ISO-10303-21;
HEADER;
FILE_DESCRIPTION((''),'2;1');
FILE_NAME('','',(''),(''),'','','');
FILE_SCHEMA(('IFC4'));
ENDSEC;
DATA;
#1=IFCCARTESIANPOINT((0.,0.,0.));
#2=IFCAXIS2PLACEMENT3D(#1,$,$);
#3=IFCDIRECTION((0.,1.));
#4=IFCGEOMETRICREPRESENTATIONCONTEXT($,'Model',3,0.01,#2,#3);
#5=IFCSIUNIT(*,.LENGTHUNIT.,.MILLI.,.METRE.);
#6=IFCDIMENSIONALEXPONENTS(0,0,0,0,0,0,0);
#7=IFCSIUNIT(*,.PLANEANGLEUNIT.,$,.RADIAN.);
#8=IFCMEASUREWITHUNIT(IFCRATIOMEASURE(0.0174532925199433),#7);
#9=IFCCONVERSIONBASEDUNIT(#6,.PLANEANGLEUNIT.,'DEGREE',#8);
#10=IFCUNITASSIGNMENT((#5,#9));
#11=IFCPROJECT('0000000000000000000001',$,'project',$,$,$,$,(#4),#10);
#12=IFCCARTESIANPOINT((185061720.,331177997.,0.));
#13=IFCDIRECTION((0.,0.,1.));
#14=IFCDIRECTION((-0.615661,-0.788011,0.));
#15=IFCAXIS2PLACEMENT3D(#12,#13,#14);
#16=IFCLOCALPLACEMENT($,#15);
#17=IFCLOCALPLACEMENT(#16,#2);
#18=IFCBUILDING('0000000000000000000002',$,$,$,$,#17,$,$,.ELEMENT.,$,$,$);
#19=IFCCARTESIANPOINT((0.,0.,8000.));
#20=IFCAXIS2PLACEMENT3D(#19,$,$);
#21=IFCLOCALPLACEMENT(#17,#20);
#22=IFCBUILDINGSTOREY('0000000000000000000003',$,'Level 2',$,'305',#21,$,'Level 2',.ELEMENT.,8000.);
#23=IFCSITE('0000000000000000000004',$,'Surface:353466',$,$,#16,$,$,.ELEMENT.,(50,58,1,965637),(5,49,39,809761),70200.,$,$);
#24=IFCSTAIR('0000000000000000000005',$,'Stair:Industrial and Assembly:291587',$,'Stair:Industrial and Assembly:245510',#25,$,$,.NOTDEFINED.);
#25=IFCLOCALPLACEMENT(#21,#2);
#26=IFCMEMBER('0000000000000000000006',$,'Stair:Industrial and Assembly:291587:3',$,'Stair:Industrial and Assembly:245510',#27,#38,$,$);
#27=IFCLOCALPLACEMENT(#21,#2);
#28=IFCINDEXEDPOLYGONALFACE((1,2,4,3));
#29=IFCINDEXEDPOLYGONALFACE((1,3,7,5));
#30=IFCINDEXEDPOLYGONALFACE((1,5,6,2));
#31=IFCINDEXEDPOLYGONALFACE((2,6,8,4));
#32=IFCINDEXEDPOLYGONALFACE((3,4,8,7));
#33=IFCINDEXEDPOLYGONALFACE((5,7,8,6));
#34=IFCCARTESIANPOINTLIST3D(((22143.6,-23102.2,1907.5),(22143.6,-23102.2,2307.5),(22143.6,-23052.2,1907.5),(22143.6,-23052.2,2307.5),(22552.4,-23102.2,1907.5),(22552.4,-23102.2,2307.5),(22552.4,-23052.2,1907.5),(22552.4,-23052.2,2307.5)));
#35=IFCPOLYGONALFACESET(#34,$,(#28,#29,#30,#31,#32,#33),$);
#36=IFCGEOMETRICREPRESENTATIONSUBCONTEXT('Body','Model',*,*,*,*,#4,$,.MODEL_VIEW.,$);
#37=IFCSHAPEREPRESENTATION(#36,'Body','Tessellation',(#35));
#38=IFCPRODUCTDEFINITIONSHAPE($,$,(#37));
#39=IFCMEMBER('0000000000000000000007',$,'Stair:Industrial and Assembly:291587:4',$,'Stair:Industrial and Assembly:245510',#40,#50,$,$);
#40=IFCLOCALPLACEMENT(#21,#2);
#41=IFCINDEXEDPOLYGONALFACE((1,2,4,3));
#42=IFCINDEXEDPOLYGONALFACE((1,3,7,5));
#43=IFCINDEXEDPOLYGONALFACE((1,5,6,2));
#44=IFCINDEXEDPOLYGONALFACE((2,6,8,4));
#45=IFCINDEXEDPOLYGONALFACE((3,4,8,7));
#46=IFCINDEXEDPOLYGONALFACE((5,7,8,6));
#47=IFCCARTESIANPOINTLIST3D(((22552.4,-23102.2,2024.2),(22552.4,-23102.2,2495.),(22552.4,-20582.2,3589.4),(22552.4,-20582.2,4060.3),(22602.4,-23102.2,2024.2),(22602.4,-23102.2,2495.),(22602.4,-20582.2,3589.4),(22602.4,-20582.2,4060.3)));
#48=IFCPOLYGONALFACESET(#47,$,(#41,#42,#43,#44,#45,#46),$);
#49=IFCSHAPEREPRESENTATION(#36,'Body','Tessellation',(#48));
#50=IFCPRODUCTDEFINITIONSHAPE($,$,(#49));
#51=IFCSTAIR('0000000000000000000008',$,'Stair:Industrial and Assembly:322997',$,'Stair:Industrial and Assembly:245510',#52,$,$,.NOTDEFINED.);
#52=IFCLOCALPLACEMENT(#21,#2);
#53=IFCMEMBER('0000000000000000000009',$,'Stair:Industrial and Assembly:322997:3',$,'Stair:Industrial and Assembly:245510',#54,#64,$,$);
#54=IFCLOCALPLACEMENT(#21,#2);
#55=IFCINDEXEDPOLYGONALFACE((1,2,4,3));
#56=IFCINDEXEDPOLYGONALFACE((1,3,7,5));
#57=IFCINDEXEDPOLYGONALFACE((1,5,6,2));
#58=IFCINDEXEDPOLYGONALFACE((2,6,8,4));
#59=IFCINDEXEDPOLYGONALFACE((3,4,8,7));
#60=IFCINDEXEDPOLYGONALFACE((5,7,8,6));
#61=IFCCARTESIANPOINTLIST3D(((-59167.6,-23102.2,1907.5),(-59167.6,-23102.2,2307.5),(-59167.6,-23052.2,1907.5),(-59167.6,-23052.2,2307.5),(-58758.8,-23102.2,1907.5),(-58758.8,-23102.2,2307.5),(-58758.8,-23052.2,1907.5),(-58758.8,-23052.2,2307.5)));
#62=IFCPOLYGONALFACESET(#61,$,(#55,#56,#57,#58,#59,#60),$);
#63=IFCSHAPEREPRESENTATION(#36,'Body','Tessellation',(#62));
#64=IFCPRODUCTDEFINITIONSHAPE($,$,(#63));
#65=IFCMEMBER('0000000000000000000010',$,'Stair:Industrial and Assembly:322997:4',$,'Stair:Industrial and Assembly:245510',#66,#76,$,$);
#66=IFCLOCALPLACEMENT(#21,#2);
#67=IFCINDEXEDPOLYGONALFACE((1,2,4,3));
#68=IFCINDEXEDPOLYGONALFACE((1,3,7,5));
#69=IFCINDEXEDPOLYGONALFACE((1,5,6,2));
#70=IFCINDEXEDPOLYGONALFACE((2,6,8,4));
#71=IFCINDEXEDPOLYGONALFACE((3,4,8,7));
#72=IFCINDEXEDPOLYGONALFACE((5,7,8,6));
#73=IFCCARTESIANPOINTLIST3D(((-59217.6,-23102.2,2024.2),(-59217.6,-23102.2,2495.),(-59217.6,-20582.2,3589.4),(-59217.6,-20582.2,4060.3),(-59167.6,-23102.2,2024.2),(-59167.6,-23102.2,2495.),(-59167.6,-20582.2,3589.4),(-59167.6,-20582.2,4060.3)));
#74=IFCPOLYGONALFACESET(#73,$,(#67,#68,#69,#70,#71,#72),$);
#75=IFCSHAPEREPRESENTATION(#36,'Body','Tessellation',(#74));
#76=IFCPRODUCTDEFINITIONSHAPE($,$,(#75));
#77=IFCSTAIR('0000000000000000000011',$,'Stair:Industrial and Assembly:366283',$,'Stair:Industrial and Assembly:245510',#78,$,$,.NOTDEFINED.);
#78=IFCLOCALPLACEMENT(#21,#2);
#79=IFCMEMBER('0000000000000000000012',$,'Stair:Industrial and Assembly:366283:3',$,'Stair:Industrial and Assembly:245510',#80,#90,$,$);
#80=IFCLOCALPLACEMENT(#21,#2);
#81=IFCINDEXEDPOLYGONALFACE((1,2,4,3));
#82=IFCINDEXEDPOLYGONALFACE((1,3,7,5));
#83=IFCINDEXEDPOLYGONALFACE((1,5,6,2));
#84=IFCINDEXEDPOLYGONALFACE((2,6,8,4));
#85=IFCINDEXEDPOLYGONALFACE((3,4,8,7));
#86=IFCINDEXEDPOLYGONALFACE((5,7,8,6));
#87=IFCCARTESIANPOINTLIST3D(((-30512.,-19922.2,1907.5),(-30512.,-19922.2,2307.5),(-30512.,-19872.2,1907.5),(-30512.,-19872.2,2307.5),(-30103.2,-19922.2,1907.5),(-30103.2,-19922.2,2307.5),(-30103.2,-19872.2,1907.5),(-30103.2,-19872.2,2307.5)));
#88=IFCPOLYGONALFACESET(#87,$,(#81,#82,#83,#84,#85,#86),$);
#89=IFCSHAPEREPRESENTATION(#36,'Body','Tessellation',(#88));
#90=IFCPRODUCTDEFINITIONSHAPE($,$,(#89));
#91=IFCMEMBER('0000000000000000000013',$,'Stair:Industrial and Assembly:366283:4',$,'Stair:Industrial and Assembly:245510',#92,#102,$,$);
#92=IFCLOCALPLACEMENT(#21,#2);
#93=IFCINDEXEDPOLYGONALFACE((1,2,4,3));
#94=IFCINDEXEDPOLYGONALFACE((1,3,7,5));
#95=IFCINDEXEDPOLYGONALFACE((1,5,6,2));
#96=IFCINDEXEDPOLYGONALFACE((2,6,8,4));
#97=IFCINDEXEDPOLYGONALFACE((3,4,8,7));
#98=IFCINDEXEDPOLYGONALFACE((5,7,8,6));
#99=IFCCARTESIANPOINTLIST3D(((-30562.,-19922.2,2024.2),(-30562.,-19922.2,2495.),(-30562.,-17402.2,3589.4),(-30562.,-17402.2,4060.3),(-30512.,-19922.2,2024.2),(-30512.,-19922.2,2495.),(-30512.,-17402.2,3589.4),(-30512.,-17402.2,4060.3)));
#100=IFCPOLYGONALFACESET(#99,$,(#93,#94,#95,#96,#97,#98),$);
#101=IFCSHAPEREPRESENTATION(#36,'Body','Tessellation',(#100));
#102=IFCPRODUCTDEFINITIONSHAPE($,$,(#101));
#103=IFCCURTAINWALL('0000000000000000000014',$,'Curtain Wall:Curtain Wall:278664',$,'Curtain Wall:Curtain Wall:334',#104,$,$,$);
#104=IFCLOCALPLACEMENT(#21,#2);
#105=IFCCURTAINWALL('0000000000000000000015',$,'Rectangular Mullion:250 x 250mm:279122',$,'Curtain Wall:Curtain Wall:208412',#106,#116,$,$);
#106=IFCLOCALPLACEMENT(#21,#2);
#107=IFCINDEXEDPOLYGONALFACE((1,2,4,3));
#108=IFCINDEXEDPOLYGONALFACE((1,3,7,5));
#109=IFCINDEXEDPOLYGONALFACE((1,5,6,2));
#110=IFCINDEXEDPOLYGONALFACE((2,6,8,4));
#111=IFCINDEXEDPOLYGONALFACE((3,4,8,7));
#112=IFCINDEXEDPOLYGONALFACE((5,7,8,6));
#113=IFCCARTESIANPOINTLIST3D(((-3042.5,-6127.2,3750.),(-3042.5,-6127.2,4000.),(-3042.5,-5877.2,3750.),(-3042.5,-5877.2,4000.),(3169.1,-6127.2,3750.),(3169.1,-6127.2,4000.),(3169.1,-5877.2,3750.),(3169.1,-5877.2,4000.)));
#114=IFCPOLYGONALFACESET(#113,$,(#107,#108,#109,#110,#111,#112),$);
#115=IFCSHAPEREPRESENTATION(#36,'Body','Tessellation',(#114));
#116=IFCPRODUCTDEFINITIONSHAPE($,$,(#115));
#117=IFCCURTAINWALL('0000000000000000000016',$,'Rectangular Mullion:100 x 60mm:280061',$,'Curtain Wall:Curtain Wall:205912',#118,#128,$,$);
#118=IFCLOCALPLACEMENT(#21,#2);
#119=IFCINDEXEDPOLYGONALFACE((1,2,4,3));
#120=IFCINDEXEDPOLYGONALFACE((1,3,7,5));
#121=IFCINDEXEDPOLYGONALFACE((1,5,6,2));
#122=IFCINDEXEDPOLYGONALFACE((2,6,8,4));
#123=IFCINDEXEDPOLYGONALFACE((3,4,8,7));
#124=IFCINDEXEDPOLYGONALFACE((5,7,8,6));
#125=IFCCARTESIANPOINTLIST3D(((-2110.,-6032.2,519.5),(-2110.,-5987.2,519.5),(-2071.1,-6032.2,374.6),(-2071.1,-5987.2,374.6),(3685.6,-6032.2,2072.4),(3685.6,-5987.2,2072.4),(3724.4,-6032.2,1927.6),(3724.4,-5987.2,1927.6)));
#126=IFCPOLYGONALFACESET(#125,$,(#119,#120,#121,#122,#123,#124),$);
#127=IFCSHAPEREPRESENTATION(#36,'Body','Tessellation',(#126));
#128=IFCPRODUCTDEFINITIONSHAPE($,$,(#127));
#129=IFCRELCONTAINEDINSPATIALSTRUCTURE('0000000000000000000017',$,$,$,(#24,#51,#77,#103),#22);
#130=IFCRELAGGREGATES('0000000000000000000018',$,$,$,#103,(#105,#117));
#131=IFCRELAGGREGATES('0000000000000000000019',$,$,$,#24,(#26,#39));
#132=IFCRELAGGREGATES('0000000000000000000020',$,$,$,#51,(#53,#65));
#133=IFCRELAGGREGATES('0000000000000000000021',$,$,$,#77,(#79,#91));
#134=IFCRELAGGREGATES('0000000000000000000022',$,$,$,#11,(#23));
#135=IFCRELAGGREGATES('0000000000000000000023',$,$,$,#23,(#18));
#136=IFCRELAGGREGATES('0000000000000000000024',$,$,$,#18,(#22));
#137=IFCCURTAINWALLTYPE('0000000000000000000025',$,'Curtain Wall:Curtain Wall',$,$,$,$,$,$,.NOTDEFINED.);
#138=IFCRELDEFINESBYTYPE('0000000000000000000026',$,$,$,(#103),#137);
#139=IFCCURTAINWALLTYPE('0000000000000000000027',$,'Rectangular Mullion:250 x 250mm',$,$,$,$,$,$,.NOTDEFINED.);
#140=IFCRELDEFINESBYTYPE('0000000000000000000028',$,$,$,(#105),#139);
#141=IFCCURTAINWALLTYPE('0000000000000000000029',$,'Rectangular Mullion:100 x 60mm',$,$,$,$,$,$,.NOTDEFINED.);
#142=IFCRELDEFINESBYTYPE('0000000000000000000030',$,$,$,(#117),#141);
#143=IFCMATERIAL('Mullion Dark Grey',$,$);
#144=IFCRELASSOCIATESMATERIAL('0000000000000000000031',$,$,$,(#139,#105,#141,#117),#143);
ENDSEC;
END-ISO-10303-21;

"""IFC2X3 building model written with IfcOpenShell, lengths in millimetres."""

from ifc_helpers import new_model, entity, si_unit, converted_unit, direction, frame, frame_2d, origin, origin_2d_with_axis, place, context, subcontext, project, spatial, polyline, rectangle, outline, extrude, source, transform, mapped, material, type_object, type_shapes, element, aggregate, save


model = new_model("IFC2X3")

# Units and contexts
model_context = context("Model", 3, precision=0.01, world=origin(), true_north=direction((0.0, 1.0)))
body_context = subcontext(model_context, "Body", "Model", "MODEL_VIEW")
ifc_project = project(units=[si_unit("LENGTHUNIT", "METRE", prefix="MILLI"), converted_unit("PLANEANGLEUNIT", "DEGREE", entity("IfcRatioMeasure", 0.0174532925199433), si_unit("PLANEANGLEUNIT", "RADIAN"), dimensions=[0, 0, 0, 0, 0, 0, 0])], contexts=[model_context])

# Site, building, storey
site_placement = place(None, frame((185061720.0, 331177997.0, 0.0), z_axis=(0.0, 0.0, 1.0), x_axis=(-0.615661, -0.788011, 0.0)))
site = spatial("IfcSite", under=ifc_project, at=site_placement, Name="Surface:353466", CompositionType="ELEMENT", RefLatitude=(50, 58, 1, 965637), RefLongitude=(5, 49, 39, 809761), RefElevation=70200.0)
building_placement = place(site_placement, origin())
building = spatial("IfcBuilding", under=site, at=building_placement, CompositionType="ELEMENT")
storey_placement = place(building_placement, frame((0.0, 0.0, 8000.0)))
storey = spatial("IfcBuildingStorey", under=building, at=storey_placement, Name="Level 2", ObjectType="305", LongName="Level 2", CompositionType="ELEMENT", Elevation=8000.0)

# Stairs, members
stair_1_placement = place(storey_placement, origin())
stair_1 = element("IfcStair", 1, at=stair_1_placement, inside=storey, Name="Stair:Industrial and Assembly:291587", ObjectType="Stair:Industrial and Assembly:245510", ShapeType="NOTDEFINED")
member_1_placement = place(stair_1_placement, origin())
member_1 = element("IfcMember", 2, at=member_1_placement, Name="Stair:Industrial and Assembly:291587:3", ObjectType="Stair:Industrial and Assembly:245510", context=body_context, shape_type="SweptSolid", body=[
    extrude(rectangle(XDim=408.8, YDim=50.0, at=frame_2d((0.0, 0.0), x_axis=(1.0, 0.0))), frame((22348.0, -23077.2, 1907.5)), (0.0, 0.0, 1.0), 400.0),
])
member_2_placement = place(stair_1_placement, origin())
member_2 = element("IfcMember", 3, at=member_2_placement, Name="Stair:Industrial and Assembly:291587:4", ObjectType="Stair:Industrial and Assembly:245510", context=body_context, shape_type="SweptSolid", body=[
    extrude(outline(polyline([(-1607.5, -200.0), (1359.0, -200.0), (1607.5, 200.0), (-1359.0, 200.0), (-1607.5, -200.0)])), frame((22552.4, -21842.2, 3042.2), z_axis=(1.0, 0.0, 0.0), x_axis=(0.0, 0.849477, 0.527626)), (0.0, 0.0, 1.0), 50.0),
])
stair_2_placement = place(storey_placement, origin())
stair_2 = element("IfcStair", 4, at=stair_2_placement, inside=storey, Name="Stair:Industrial and Assembly:322997", ObjectType="Stair:Industrial and Assembly:245510", ShapeType="NOTDEFINED")
member_3_placement = place(stair_2_placement, origin())
member_3 = element("IfcMember", 5, at=member_3_placement, Name="Stair:Industrial and Assembly:322997:3", ObjectType="Stair:Industrial and Assembly:245510", context=body_context, shape_type="SweptSolid", body=[
    extrude(rectangle(XDim=408.8, YDim=50.0, at=frame_2d((0.0, 0.0), x_axis=(1.0, 0.0))), frame((-58963.2, -23077.2, 1907.5), z_axis=(0.0, 0.0, 1.0), x_axis=(-1.0, 0.0, 0.0)), (0.0, 0.0, 1.0), 400.0),
])
member_4_placement = place(stair_2_placement, origin())
member_4 = element("IfcMember", 6, at=member_4_placement, Name="Stair:Industrial and Assembly:322997:4", ObjectType="Stair:Industrial and Assembly:245510", context=body_context, shape_type="SweptSolid", body=[
    extrude(outline(polyline([(-1607.5, -200.0), (1359.0, -200.0), (1607.5, 200.0), (-1359.0, 200.0), (-1607.5, -200.0)])), frame((-59217.6, -21842.2, 3042.2), z_axis=(1.0, 0.0, 0.0), x_axis=(0.0, 0.849477, 0.527626)), (0.0, 0.0, 1.0), 50.0),
])
stair_3_placement = place(storey_placement, origin())
stair_3 = element("IfcStair", 7, at=stair_3_placement, inside=storey, Name="Stair:Industrial and Assembly:366283", ObjectType="Stair:Industrial and Assembly:245510", ShapeType="NOTDEFINED")
member_5_placement = place(stair_3_placement, origin())
member_5 = element("IfcMember", 8, at=member_5_placement, Name="Stair:Industrial and Assembly:366283:3", ObjectType="Stair:Industrial and Assembly:245510", context=body_context, shape_type="SweptSolid", body=[
    extrude(rectangle(XDim=408.8, YDim=50.0, at=frame_2d((0.0, 0.0), x_axis=(1.0, 0.0))), frame((-30307.6, -19897.2, 1907.5), z_axis=(0.0, 0.0, 1.0), x_axis=(-1.0, 0.0, 0.0)), (0.0, 0.0, 1.0), 400.0),
])
member_6_placement = place(stair_3_placement, origin())
member_6 = element("IfcMember", 9, at=member_6_placement, Name="Stair:Industrial and Assembly:366283:4", ObjectType="Stair:Industrial and Assembly:245510", context=body_context, shape_type="SweptSolid", body=[
    extrude(outline(polyline([(-1607.5, -200.0), (1359.0, -200.0), (1607.5, 200.0), (-1359.0, 200.0), (-1607.5, -200.0)])), frame((-30562.0, -18662.2, 3042.2), z_axis=(1.0, 0.0, 0.0), x_axis=(0.0, 0.849477, 0.527626)), (0.0, 0.0, 1.0), 50.0),
])

# Curtain walls
curtain_wall_type_1 = type_object("IfcCurtainWallType", Name="Curtain Wall:Curtain Wall", PredefinedType="NOTDEFINED")
curtain_wall_1_placement = place(storey_placement, frame((0.0, 0.0, -8000.0)))
curtain_wall_1 = element("IfcCurtainWall", 10, at=curtain_wall_1_placement, inside=storey, type_object=curtain_wall_type_1, Name="Curtain Wall:Curtain Wall:278664", ObjectType="Curtain Wall:Curtain Wall:334")
ifc_material_1 = material(Name="Mullion Dark Grey")
curtain_wall_type_2 = type_object("IfcCurtainWallType", Name="Rectangular Mullion:250 x 250mm", PredefinedType="NOTDEFINED", material=ifc_material_1)
shared_shape_1 = source(origin(), body_context, "Body", "SweptSolid", [
    extrude(rectangle(XDim=250.0, YDim=250.0, at=origin_2d_with_axis()), frame((-125.0, 0.0, -6211.7), z_axis=(0.0, 0.0, 1.0), x_axis=(-1.0, 0.0, 0.0)), (0.0, 0.0, 1.0), 6211.7),
])
type_shapes(curtain_wall_type_2, [shared_shape_1])
curtain_wall_2_placement = place(storey_placement, frame((3169.1, -6002.2, 4000.0), z_axis=(1.0, 0.0, 0.0), x_axis=(0.0, 0.0, 1.0)))
curtain_wall_2 = element("IfcCurtainWall", 11, at=curtain_wall_2_placement, type_object=curtain_wall_type_2, material=ifc_material_1, Name="Rectangular Mullion:250 x 250mm:279122", ObjectType="Curtain Wall:Curtain Wall:208412", context=body_context, shape_type="MappedRepresentation", body=[
    mapped(shared_shape_1, transform((0.0, 0.0, 0.0), scale=1.0)),
])
curtain_wall_type_3 = type_object("IfcCurtainWallType", Name="Rectangular Mullion:100 x 60mm", PredefinedType="NOTDEFINED", material=ifc_material_1)
shared_shape_2 = source(origin(), body_context, "Body", "SweptSolid", [
    extrude(rectangle(XDim=45.0, YDim=150.0, at=frame_2d((0.0, 0.0), x_axis=(1.0, 0.0))), frame((0.0, 7.5, -6000.0), z_axis=(0.0, 0.0, 1.0), x_axis=(0.0, -1.0, 0.0)), (0.0, 0.0, 1.0), 6000.0),
])
type_shapes(curtain_wall_type_3, [shared_shape_2])
curtain_wall_3_placement = place(storey_placement, frame((3705.0, -6002.2, 2000.0), z_axis=(0.965926, 0.0, 0.258819), x_axis=(-0.258819, 0.0, 0.965926)))
curtain_wall_3 = element("IfcCurtainWall", 12, at=curtain_wall_3_placement, type_object=curtain_wall_type_3, material=ifc_material_1, Name="Rectangular Mullion:100 x 60mm:280061", ObjectType="Curtain Wall:Curtain Wall:205912", context=body_context, shape_type="MappedRepresentation", body=[
    mapped(shared_shape_2, transform((0.0, 0.0, 0.0), scale=1.0)),
])
aggregate(curtain_wall_1, [curtain_wall_2, curtain_wall_3])

aggregate(stair_1, [member_1, member_2])
aggregate(stair_2, [member_3, member_4])
aggregate(stair_3, [member_5, member_6])

save(model, "model.ifc")
